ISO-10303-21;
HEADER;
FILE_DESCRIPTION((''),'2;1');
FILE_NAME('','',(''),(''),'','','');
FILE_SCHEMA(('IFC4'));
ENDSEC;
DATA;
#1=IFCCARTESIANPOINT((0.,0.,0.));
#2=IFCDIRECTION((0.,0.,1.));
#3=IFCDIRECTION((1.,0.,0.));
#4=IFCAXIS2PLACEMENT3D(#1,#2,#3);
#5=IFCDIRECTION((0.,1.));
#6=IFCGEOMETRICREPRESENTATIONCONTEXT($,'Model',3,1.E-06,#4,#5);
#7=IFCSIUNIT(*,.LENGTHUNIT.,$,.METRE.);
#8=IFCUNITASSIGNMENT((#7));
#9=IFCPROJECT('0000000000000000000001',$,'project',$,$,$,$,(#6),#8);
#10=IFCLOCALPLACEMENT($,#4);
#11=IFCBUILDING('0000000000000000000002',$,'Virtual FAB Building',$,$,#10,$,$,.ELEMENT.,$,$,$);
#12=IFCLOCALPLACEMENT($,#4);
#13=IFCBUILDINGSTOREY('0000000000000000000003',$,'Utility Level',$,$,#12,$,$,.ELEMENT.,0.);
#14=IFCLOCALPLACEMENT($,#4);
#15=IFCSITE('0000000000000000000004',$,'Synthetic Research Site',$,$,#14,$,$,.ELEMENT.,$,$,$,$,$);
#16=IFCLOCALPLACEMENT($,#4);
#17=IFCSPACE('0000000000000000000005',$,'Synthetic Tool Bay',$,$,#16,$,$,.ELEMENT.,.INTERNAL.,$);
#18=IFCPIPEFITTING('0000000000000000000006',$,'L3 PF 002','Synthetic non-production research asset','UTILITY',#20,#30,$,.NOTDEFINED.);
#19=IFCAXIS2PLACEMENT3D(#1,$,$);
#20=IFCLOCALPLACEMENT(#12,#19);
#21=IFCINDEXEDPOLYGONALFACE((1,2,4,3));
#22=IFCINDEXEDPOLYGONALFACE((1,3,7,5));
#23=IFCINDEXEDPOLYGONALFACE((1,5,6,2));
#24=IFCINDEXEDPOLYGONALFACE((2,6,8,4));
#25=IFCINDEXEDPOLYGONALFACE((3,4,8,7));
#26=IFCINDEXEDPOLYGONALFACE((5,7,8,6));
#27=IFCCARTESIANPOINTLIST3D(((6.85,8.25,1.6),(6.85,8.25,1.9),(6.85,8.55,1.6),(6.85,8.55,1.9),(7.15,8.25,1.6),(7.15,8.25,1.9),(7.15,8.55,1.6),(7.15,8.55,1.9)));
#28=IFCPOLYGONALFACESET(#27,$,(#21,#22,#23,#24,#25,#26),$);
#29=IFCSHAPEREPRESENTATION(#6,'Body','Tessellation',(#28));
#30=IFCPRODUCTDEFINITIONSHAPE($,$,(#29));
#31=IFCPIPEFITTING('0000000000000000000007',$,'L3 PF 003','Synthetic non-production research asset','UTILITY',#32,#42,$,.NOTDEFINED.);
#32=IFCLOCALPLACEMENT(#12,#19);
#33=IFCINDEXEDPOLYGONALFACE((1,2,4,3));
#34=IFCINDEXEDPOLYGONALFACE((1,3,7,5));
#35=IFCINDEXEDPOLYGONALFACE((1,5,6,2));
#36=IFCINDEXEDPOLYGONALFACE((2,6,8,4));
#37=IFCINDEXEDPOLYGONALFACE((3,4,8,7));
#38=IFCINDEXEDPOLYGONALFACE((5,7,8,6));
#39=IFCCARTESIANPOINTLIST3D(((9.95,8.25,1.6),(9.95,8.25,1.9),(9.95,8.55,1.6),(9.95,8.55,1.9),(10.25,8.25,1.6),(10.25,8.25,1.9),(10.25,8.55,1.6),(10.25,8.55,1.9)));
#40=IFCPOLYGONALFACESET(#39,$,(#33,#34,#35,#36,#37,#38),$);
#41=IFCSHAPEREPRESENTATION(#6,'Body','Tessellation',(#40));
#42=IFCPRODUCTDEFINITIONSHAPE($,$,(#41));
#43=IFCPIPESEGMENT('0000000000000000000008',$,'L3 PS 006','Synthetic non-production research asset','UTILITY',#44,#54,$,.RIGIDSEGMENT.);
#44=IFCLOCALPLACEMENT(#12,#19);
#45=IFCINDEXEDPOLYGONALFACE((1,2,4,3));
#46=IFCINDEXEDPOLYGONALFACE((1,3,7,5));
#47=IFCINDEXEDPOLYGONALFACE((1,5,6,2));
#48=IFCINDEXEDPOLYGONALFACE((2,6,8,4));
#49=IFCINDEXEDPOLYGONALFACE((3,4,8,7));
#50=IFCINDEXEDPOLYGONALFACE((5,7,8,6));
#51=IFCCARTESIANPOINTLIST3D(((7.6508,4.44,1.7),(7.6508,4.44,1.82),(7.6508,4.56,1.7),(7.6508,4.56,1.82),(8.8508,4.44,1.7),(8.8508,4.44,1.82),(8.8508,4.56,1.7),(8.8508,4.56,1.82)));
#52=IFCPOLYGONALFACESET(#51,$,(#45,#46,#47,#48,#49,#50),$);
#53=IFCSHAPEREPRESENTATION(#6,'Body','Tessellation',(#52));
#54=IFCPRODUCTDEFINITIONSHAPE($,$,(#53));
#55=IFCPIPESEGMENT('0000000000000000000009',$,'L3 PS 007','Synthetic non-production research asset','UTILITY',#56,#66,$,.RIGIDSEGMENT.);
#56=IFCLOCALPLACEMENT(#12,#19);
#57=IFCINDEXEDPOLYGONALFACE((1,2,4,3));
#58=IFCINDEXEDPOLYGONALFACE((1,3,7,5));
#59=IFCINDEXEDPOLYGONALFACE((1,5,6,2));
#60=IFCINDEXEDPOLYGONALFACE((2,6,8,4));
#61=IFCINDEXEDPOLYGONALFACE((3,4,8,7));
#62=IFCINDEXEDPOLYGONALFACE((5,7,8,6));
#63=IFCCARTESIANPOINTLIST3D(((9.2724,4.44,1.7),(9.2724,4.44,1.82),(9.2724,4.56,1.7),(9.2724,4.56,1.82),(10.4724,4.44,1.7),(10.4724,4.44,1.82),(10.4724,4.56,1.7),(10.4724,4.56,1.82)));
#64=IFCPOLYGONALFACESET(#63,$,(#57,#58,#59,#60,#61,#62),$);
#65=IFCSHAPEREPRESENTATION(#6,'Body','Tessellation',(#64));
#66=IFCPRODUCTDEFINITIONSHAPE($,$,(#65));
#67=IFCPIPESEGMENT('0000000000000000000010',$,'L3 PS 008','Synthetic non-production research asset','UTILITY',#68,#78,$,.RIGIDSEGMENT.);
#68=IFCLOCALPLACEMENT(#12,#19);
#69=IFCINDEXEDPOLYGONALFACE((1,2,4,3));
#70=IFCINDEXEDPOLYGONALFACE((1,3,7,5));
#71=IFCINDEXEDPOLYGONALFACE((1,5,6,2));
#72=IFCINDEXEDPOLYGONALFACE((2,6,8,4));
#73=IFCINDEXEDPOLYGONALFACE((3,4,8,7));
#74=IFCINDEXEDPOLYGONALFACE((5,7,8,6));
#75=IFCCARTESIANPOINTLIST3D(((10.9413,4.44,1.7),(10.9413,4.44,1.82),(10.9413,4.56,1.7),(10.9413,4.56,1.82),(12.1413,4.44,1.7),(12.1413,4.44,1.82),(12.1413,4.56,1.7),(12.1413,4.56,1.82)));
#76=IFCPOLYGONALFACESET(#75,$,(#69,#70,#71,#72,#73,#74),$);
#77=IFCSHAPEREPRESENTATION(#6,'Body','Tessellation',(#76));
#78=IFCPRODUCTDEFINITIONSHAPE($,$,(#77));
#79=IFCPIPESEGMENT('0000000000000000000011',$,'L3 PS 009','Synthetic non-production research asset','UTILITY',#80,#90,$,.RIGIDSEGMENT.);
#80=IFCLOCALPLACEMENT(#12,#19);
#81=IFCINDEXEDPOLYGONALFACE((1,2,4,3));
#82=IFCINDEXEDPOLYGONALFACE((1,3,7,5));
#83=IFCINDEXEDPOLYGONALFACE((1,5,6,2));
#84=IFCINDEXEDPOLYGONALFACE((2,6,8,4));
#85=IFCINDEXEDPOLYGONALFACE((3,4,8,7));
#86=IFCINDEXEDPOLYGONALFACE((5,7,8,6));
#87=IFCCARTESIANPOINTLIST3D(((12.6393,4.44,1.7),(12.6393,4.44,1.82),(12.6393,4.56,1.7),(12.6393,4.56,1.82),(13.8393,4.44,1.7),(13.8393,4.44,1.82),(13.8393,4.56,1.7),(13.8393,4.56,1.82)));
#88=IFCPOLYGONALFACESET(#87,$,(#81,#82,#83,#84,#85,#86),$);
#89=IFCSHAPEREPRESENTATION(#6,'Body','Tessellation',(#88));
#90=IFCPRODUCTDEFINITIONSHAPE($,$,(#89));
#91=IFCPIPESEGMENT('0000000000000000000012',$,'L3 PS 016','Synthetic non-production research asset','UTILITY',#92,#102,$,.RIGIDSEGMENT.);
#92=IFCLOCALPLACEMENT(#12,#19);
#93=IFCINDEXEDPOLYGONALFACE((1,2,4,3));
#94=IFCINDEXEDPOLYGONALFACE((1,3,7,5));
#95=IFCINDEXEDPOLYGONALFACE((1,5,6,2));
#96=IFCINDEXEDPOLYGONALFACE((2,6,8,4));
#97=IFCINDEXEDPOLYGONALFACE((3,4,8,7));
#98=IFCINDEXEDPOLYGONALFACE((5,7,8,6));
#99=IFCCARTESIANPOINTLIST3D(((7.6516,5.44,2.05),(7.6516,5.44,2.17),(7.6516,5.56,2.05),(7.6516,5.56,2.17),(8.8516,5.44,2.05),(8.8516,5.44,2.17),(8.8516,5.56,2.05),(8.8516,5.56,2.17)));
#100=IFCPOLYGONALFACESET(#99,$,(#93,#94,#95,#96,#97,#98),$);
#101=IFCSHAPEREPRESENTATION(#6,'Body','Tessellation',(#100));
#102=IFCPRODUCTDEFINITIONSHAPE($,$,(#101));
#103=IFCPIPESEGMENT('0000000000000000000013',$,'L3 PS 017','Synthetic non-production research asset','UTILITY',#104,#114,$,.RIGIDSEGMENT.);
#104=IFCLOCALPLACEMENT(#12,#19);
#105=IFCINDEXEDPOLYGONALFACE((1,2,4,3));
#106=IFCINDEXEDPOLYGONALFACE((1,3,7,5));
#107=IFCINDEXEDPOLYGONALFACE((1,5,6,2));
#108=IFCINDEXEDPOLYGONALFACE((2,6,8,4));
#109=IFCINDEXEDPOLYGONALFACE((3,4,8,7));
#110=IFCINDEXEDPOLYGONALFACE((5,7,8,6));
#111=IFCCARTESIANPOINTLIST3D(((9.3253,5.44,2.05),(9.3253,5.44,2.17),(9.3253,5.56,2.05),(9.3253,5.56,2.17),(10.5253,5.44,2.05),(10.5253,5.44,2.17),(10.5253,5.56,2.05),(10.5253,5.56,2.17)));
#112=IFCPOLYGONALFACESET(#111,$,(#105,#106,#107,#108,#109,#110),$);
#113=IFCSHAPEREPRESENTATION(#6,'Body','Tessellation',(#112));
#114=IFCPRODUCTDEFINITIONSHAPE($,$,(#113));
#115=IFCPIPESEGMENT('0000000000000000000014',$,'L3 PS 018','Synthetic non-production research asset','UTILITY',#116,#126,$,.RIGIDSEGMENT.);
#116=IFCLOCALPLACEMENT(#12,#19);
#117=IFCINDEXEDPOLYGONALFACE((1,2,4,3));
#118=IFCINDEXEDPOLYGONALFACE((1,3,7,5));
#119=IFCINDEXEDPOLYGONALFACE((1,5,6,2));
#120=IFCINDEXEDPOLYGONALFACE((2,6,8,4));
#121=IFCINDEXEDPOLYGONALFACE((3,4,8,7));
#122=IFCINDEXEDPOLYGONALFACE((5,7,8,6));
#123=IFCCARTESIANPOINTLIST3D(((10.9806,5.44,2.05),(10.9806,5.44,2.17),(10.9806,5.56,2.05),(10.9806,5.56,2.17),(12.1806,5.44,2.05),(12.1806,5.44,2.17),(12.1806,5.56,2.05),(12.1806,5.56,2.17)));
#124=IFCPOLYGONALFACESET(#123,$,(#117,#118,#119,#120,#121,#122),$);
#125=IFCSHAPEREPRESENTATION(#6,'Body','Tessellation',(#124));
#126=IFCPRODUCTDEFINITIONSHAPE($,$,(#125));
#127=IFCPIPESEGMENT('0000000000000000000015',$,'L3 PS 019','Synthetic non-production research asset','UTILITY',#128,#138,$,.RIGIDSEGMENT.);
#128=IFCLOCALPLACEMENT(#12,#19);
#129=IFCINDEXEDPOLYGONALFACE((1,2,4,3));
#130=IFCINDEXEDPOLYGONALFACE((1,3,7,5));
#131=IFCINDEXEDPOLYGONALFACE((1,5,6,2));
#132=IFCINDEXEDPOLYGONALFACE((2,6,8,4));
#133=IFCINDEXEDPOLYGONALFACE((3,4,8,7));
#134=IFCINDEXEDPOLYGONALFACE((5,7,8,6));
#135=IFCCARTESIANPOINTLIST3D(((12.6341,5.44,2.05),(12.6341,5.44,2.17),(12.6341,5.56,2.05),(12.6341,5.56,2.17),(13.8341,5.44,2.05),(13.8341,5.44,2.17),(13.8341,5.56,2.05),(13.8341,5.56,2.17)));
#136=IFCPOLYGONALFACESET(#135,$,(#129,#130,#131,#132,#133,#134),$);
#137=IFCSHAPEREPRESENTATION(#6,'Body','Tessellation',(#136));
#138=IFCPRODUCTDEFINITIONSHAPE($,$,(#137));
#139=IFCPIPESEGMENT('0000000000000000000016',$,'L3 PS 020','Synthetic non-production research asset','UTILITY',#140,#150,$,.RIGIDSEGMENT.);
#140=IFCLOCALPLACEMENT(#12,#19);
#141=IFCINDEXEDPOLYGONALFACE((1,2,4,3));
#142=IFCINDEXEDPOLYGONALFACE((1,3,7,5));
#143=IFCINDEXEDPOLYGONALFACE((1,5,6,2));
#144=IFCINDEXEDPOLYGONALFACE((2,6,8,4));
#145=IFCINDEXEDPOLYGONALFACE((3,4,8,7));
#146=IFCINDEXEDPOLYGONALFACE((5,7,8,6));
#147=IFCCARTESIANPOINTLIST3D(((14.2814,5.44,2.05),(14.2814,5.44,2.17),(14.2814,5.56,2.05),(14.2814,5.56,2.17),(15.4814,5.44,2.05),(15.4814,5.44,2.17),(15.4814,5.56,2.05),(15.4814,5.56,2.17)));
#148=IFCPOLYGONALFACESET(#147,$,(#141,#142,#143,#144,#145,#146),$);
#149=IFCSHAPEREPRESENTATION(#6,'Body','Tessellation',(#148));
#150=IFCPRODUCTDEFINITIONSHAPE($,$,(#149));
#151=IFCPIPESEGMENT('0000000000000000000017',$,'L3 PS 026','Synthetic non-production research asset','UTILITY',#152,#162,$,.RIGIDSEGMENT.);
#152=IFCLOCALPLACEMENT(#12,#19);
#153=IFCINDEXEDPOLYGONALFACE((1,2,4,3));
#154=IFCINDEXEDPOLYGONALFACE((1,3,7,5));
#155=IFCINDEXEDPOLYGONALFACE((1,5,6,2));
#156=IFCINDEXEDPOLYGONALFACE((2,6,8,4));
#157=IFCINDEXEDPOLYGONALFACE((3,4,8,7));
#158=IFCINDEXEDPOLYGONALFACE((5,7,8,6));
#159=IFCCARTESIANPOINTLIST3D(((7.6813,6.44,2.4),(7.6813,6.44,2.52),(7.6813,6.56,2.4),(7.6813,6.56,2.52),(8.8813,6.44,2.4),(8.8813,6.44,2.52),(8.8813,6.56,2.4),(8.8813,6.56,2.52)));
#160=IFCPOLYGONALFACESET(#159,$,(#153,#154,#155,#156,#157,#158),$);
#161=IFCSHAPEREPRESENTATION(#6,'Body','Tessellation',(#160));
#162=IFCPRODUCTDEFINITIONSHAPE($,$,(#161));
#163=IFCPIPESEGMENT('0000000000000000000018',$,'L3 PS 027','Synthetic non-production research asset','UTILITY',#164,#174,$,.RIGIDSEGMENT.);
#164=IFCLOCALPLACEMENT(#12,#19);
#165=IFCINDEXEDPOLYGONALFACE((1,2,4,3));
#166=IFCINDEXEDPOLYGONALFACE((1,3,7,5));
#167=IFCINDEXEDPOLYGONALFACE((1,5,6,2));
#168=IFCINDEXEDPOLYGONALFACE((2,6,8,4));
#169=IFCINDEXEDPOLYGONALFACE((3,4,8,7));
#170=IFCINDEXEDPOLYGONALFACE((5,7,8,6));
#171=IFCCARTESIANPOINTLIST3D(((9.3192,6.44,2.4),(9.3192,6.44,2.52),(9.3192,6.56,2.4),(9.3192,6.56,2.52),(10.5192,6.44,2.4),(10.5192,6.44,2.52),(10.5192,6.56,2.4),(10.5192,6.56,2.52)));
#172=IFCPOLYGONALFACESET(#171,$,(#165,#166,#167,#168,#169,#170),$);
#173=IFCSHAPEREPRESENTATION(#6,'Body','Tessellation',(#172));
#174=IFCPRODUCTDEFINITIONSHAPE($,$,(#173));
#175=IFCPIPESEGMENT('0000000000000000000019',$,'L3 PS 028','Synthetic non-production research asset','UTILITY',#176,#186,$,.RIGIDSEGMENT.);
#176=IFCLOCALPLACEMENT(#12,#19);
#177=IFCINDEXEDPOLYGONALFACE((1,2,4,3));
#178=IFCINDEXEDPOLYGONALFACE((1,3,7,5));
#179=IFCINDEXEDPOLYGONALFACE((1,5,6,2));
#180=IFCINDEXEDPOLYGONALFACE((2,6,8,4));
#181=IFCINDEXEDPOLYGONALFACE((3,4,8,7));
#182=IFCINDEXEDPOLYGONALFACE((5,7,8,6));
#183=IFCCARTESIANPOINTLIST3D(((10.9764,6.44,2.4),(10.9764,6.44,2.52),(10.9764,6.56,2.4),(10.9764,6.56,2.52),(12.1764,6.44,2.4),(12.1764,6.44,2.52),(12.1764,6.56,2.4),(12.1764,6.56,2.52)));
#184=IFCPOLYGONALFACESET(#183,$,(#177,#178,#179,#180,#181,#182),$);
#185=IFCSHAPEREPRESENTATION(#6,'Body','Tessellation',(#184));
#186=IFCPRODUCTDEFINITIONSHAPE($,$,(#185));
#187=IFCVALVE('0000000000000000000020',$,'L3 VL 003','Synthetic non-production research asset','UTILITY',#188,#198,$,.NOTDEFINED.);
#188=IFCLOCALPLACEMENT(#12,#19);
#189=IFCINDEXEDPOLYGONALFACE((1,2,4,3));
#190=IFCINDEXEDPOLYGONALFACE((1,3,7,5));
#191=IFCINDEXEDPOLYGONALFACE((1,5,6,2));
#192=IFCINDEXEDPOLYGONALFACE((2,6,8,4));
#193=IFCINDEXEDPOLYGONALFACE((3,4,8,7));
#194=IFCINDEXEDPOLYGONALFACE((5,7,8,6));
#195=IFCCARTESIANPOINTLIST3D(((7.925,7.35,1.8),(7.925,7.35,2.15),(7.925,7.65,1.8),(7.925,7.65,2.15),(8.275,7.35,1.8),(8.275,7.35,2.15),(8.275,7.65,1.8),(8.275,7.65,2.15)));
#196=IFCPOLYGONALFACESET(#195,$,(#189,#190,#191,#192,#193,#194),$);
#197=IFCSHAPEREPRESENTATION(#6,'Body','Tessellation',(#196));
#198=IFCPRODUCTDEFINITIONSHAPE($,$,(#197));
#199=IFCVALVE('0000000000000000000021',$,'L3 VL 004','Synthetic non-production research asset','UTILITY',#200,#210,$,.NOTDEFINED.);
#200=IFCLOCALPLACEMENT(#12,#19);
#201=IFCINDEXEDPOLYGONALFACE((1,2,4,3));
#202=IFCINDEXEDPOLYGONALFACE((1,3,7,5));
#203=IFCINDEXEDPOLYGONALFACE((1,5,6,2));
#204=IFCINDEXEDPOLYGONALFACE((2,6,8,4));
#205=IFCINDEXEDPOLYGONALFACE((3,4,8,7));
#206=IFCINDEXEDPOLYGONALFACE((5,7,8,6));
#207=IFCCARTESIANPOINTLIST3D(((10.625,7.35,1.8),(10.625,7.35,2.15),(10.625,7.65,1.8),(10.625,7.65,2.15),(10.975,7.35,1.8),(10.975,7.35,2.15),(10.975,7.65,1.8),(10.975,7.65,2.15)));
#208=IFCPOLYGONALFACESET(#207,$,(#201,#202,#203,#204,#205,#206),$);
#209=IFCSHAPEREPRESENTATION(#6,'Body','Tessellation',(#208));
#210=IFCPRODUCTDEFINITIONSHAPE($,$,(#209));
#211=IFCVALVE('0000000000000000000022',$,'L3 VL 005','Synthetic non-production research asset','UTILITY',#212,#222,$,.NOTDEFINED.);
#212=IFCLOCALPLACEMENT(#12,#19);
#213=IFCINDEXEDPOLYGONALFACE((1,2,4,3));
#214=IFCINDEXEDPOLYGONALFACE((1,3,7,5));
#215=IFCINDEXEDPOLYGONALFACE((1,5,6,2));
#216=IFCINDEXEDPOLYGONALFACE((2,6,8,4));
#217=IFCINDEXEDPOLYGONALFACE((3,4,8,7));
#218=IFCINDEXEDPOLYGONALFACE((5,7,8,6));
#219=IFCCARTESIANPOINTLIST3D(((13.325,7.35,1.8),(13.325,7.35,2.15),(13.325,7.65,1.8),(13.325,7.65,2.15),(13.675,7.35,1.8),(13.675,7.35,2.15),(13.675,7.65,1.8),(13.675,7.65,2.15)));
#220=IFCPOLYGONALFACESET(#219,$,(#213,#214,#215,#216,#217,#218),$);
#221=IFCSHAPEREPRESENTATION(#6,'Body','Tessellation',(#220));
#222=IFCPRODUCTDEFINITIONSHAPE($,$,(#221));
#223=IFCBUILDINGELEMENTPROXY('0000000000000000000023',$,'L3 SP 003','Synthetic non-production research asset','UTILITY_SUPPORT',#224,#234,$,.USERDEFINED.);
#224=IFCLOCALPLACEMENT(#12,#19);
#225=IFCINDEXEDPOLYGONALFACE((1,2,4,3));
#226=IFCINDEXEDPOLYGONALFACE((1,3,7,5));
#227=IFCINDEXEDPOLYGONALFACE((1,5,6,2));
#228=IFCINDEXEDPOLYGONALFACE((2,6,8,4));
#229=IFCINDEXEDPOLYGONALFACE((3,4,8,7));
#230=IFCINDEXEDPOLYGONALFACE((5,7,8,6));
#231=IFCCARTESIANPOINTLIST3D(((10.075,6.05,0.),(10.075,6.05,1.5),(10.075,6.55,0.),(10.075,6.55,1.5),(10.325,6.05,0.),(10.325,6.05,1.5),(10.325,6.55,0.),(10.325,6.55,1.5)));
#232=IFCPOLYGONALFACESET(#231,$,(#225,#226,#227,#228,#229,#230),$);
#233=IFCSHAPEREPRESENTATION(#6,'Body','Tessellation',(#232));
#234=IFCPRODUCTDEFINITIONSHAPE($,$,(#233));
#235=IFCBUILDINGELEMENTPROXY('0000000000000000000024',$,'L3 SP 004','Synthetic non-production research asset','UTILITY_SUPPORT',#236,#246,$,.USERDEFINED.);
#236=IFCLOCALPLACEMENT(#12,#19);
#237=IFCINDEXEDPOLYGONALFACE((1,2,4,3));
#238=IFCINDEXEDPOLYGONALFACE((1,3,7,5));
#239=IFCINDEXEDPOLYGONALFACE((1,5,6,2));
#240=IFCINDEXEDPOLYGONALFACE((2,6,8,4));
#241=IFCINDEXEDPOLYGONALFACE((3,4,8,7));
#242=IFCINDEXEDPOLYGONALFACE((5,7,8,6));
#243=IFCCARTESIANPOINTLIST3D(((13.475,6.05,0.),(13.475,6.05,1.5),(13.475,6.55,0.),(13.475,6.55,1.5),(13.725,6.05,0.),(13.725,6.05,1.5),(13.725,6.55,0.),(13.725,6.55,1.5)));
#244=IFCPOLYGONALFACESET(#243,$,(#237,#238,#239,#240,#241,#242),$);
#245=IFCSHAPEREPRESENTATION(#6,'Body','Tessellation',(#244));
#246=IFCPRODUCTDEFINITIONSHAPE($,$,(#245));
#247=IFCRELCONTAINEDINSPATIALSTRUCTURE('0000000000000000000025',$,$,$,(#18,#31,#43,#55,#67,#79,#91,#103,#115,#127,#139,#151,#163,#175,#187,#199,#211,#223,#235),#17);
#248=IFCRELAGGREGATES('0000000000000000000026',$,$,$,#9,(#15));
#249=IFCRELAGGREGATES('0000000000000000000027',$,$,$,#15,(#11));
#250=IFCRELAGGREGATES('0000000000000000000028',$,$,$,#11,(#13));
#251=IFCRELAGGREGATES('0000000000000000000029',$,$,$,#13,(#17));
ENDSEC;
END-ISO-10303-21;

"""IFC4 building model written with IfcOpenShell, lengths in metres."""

from ifc_helpers import new_model, si_unit, direction, frame, origin_with_axes, origin_2d_with_axis, place, context, project, spatial, rectangle, extrude, element, save


model = new_model("IFC4")

# Units and contexts
model_context = context("Model", 3, precision=1e-06, world=origin_with_axes(), true_north=direction((0.0, 1.0)))
ifc_project = project(units=[si_unit("LENGTHUNIT", "METRE")], contexts=[model_context])

# Site, building, storey, space
site_placement = place(None, origin_with_axes())
site = spatial("IfcSite", under=ifc_project, at=site_placement, Name="Synthetic Research Site", CompositionType="ELEMENT")
building_placement = place(None, origin_with_axes())
building = spatial("IfcBuilding", under=site, at=building_placement, Name="Virtual FAB Building", CompositionType="ELEMENT")
storey_placement = place(None, origin_with_axes())
storey = spatial("IfcBuildingStorey", under=building, at=storey_placement, Name="Utility Level", CompositionType="ELEMENT", Elevation=0.0)
space_placement = place(None, origin_with_axes())
space = spatial("IfcSpace", under=storey, at=space_placement, Name="Synthetic Tool Bay", CompositionType="ELEMENT", PredefinedType="INTERNAL")

# Pipe fittings
for number, where, z_axis, x_axis, name in (
    (1, (7.0, 8.4, 1.6), (0.0, 0.0, 1.0), (1.0, 0.0, 0.0), "L3 PF 002"),
    (2, (10.1, 8.4, 1.6), (0.0, 0.0, 1.0), (1.0, 0.0, 0.0), "L3 PF 003"),
):
    element("IfcPipeFitting", number, at=place(None, frame(where, z_axis=z_axis, x_axis=x_axis)), inside=space, Name=name, Description="Synthetic non-production research asset", ObjectType="UTILITY", PredefinedType="NOTDEFINED", context=model_context, shape_type="SweptSolid", body=[
        extrude(rectangle(XDim=0.3, YDim=0.3, at=origin_2d_with_axis()), origin_with_axes(), (0.0, 0.0, 1.0), 0.3),
    ])

# Pipe segments
for number, where, z_axis, x_axis, name in (
    (3, (8.2508, 4.5, 1.7), (0.0, 0.0, 1.0), (1.0, 0.0, 0.0), "L3 PS 006"),
    (4, (9.8724, 4.5, 1.7), (0.0, 0.0, 1.0), (1.0, 0.0, 0.0), "L3 PS 007"),
    (5, (11.5413, 4.5, 1.7), (0.0, 0.0, 1.0), (1.0, 0.0, 0.0), "L3 PS 008"),
    (6, (13.2393, 4.5, 1.7), (0.0, 0.0, 1.0), (1.0, 0.0, 0.0), "L3 PS 009"),
    (7, (8.2516, 5.5, 2.05), (0.0, 0.0, 1.0), (1.0, 0.0, 0.0), "L3 PS 016"),
    (8, (9.9253, 5.5, 2.05), (0.0, 0.0, 1.0), (1.0, 0.0, 0.0), "L3 PS 017"),
    (9, (11.5806, 5.5, 2.05), (0.0, 0.0, 1.0), (1.0, 0.0, 0.0), "L3 PS 018"),
    (10, (13.2341, 5.5, 2.05), (0.0, 0.0, 1.0), (1.0, 0.0, 0.0), "L3 PS 019"),
    (11, (14.8814, 5.5, 2.05), (0.0, 0.0, 1.0), (1.0, 0.0, 0.0), "L3 PS 020"),
    (12, (8.2813, 6.5, 2.4), (0.0, 0.0, 1.0), (1.0, 0.0, 0.0), "L3 PS 026"),
    (13, (9.9192, 6.5, 2.4), (0.0, 0.0, 1.0), (1.0, 0.0, 0.0), "L3 PS 027"),
    (14, (11.5764, 6.5, 2.4), (0.0, 0.0, 1.0), (1.0, 0.0, 0.0), "L3 PS 028"),
):
    element("IfcPipeSegment", number, at=place(None, frame(where, z_axis=z_axis, x_axis=x_axis)), inside=space, Name=name, Description="Synthetic non-production research asset", ObjectType="UTILITY", PredefinedType="RIGIDSEGMENT", context=model_context, shape_type="SweptSolid", body=[
        extrude(rectangle(XDim=1.2, YDim=0.12, at=origin_2d_with_axis()), origin_with_axes(), (0.0, 0.0, 1.0), 0.12),
    ])

# Valves
for number, where, z_axis, x_axis, name in (
    (15, (8.1, 7.5, 1.8), (0.0, 0.0, 1.0), (1.0, 0.0, 0.0), "L3 VL 003"),
    (16, (10.8, 7.5, 1.8), (0.0, 0.0, 1.0), (1.0, 0.0, 0.0), "L3 VL 004"),
    (17, (13.5, 7.5, 1.8), (0.0, 0.0, 1.0), (1.0, 0.0, 0.0), "L3 VL 005"),
):
    element("IfcValve", number, at=place(None, frame(where, z_axis=z_axis, x_axis=x_axis)), inside=space, Name=name, Description="Synthetic non-production research asset", ObjectType="UTILITY", PredefinedType="NOTDEFINED", context=model_context, shape_type="SweptSolid", body=[
        extrude(rectangle(XDim=0.35, YDim=0.3, at=origin_2d_with_axis()), origin_with_axes(), (0.0, 0.0, 1.0), 0.35),
    ])

# Building element proxies
for number, where, z_axis, x_axis, name in (
    (18, (10.2, 6.3, 0.0), (0.0, 0.0, 1.0), (1.0, 0.0, 0.0), "L3 SP 003"),
    (19, (13.6, 6.3, 0.0), (0.0, 0.0, 1.0), (1.0, 0.0, 0.0), "L3 SP 004"),
):
    element("IfcBuildingElementProxy", number, at=place(None, frame(where, z_axis=z_axis, x_axis=x_axis)), inside=space, Name=name, Description="Synthetic non-production research asset", ObjectType="UTILITY_SUPPORT", PredefinedType="USERDEFINED", context=model_context, shape_type="SweptSolid", body=[
        extrude(rectangle(XDim=0.25, YDim=0.5, at=origin_2d_with_axis()), origin_with_axes(), (0.0, 0.0, 1.0), 1.5),
    ])

save(model, "model.ifc")
